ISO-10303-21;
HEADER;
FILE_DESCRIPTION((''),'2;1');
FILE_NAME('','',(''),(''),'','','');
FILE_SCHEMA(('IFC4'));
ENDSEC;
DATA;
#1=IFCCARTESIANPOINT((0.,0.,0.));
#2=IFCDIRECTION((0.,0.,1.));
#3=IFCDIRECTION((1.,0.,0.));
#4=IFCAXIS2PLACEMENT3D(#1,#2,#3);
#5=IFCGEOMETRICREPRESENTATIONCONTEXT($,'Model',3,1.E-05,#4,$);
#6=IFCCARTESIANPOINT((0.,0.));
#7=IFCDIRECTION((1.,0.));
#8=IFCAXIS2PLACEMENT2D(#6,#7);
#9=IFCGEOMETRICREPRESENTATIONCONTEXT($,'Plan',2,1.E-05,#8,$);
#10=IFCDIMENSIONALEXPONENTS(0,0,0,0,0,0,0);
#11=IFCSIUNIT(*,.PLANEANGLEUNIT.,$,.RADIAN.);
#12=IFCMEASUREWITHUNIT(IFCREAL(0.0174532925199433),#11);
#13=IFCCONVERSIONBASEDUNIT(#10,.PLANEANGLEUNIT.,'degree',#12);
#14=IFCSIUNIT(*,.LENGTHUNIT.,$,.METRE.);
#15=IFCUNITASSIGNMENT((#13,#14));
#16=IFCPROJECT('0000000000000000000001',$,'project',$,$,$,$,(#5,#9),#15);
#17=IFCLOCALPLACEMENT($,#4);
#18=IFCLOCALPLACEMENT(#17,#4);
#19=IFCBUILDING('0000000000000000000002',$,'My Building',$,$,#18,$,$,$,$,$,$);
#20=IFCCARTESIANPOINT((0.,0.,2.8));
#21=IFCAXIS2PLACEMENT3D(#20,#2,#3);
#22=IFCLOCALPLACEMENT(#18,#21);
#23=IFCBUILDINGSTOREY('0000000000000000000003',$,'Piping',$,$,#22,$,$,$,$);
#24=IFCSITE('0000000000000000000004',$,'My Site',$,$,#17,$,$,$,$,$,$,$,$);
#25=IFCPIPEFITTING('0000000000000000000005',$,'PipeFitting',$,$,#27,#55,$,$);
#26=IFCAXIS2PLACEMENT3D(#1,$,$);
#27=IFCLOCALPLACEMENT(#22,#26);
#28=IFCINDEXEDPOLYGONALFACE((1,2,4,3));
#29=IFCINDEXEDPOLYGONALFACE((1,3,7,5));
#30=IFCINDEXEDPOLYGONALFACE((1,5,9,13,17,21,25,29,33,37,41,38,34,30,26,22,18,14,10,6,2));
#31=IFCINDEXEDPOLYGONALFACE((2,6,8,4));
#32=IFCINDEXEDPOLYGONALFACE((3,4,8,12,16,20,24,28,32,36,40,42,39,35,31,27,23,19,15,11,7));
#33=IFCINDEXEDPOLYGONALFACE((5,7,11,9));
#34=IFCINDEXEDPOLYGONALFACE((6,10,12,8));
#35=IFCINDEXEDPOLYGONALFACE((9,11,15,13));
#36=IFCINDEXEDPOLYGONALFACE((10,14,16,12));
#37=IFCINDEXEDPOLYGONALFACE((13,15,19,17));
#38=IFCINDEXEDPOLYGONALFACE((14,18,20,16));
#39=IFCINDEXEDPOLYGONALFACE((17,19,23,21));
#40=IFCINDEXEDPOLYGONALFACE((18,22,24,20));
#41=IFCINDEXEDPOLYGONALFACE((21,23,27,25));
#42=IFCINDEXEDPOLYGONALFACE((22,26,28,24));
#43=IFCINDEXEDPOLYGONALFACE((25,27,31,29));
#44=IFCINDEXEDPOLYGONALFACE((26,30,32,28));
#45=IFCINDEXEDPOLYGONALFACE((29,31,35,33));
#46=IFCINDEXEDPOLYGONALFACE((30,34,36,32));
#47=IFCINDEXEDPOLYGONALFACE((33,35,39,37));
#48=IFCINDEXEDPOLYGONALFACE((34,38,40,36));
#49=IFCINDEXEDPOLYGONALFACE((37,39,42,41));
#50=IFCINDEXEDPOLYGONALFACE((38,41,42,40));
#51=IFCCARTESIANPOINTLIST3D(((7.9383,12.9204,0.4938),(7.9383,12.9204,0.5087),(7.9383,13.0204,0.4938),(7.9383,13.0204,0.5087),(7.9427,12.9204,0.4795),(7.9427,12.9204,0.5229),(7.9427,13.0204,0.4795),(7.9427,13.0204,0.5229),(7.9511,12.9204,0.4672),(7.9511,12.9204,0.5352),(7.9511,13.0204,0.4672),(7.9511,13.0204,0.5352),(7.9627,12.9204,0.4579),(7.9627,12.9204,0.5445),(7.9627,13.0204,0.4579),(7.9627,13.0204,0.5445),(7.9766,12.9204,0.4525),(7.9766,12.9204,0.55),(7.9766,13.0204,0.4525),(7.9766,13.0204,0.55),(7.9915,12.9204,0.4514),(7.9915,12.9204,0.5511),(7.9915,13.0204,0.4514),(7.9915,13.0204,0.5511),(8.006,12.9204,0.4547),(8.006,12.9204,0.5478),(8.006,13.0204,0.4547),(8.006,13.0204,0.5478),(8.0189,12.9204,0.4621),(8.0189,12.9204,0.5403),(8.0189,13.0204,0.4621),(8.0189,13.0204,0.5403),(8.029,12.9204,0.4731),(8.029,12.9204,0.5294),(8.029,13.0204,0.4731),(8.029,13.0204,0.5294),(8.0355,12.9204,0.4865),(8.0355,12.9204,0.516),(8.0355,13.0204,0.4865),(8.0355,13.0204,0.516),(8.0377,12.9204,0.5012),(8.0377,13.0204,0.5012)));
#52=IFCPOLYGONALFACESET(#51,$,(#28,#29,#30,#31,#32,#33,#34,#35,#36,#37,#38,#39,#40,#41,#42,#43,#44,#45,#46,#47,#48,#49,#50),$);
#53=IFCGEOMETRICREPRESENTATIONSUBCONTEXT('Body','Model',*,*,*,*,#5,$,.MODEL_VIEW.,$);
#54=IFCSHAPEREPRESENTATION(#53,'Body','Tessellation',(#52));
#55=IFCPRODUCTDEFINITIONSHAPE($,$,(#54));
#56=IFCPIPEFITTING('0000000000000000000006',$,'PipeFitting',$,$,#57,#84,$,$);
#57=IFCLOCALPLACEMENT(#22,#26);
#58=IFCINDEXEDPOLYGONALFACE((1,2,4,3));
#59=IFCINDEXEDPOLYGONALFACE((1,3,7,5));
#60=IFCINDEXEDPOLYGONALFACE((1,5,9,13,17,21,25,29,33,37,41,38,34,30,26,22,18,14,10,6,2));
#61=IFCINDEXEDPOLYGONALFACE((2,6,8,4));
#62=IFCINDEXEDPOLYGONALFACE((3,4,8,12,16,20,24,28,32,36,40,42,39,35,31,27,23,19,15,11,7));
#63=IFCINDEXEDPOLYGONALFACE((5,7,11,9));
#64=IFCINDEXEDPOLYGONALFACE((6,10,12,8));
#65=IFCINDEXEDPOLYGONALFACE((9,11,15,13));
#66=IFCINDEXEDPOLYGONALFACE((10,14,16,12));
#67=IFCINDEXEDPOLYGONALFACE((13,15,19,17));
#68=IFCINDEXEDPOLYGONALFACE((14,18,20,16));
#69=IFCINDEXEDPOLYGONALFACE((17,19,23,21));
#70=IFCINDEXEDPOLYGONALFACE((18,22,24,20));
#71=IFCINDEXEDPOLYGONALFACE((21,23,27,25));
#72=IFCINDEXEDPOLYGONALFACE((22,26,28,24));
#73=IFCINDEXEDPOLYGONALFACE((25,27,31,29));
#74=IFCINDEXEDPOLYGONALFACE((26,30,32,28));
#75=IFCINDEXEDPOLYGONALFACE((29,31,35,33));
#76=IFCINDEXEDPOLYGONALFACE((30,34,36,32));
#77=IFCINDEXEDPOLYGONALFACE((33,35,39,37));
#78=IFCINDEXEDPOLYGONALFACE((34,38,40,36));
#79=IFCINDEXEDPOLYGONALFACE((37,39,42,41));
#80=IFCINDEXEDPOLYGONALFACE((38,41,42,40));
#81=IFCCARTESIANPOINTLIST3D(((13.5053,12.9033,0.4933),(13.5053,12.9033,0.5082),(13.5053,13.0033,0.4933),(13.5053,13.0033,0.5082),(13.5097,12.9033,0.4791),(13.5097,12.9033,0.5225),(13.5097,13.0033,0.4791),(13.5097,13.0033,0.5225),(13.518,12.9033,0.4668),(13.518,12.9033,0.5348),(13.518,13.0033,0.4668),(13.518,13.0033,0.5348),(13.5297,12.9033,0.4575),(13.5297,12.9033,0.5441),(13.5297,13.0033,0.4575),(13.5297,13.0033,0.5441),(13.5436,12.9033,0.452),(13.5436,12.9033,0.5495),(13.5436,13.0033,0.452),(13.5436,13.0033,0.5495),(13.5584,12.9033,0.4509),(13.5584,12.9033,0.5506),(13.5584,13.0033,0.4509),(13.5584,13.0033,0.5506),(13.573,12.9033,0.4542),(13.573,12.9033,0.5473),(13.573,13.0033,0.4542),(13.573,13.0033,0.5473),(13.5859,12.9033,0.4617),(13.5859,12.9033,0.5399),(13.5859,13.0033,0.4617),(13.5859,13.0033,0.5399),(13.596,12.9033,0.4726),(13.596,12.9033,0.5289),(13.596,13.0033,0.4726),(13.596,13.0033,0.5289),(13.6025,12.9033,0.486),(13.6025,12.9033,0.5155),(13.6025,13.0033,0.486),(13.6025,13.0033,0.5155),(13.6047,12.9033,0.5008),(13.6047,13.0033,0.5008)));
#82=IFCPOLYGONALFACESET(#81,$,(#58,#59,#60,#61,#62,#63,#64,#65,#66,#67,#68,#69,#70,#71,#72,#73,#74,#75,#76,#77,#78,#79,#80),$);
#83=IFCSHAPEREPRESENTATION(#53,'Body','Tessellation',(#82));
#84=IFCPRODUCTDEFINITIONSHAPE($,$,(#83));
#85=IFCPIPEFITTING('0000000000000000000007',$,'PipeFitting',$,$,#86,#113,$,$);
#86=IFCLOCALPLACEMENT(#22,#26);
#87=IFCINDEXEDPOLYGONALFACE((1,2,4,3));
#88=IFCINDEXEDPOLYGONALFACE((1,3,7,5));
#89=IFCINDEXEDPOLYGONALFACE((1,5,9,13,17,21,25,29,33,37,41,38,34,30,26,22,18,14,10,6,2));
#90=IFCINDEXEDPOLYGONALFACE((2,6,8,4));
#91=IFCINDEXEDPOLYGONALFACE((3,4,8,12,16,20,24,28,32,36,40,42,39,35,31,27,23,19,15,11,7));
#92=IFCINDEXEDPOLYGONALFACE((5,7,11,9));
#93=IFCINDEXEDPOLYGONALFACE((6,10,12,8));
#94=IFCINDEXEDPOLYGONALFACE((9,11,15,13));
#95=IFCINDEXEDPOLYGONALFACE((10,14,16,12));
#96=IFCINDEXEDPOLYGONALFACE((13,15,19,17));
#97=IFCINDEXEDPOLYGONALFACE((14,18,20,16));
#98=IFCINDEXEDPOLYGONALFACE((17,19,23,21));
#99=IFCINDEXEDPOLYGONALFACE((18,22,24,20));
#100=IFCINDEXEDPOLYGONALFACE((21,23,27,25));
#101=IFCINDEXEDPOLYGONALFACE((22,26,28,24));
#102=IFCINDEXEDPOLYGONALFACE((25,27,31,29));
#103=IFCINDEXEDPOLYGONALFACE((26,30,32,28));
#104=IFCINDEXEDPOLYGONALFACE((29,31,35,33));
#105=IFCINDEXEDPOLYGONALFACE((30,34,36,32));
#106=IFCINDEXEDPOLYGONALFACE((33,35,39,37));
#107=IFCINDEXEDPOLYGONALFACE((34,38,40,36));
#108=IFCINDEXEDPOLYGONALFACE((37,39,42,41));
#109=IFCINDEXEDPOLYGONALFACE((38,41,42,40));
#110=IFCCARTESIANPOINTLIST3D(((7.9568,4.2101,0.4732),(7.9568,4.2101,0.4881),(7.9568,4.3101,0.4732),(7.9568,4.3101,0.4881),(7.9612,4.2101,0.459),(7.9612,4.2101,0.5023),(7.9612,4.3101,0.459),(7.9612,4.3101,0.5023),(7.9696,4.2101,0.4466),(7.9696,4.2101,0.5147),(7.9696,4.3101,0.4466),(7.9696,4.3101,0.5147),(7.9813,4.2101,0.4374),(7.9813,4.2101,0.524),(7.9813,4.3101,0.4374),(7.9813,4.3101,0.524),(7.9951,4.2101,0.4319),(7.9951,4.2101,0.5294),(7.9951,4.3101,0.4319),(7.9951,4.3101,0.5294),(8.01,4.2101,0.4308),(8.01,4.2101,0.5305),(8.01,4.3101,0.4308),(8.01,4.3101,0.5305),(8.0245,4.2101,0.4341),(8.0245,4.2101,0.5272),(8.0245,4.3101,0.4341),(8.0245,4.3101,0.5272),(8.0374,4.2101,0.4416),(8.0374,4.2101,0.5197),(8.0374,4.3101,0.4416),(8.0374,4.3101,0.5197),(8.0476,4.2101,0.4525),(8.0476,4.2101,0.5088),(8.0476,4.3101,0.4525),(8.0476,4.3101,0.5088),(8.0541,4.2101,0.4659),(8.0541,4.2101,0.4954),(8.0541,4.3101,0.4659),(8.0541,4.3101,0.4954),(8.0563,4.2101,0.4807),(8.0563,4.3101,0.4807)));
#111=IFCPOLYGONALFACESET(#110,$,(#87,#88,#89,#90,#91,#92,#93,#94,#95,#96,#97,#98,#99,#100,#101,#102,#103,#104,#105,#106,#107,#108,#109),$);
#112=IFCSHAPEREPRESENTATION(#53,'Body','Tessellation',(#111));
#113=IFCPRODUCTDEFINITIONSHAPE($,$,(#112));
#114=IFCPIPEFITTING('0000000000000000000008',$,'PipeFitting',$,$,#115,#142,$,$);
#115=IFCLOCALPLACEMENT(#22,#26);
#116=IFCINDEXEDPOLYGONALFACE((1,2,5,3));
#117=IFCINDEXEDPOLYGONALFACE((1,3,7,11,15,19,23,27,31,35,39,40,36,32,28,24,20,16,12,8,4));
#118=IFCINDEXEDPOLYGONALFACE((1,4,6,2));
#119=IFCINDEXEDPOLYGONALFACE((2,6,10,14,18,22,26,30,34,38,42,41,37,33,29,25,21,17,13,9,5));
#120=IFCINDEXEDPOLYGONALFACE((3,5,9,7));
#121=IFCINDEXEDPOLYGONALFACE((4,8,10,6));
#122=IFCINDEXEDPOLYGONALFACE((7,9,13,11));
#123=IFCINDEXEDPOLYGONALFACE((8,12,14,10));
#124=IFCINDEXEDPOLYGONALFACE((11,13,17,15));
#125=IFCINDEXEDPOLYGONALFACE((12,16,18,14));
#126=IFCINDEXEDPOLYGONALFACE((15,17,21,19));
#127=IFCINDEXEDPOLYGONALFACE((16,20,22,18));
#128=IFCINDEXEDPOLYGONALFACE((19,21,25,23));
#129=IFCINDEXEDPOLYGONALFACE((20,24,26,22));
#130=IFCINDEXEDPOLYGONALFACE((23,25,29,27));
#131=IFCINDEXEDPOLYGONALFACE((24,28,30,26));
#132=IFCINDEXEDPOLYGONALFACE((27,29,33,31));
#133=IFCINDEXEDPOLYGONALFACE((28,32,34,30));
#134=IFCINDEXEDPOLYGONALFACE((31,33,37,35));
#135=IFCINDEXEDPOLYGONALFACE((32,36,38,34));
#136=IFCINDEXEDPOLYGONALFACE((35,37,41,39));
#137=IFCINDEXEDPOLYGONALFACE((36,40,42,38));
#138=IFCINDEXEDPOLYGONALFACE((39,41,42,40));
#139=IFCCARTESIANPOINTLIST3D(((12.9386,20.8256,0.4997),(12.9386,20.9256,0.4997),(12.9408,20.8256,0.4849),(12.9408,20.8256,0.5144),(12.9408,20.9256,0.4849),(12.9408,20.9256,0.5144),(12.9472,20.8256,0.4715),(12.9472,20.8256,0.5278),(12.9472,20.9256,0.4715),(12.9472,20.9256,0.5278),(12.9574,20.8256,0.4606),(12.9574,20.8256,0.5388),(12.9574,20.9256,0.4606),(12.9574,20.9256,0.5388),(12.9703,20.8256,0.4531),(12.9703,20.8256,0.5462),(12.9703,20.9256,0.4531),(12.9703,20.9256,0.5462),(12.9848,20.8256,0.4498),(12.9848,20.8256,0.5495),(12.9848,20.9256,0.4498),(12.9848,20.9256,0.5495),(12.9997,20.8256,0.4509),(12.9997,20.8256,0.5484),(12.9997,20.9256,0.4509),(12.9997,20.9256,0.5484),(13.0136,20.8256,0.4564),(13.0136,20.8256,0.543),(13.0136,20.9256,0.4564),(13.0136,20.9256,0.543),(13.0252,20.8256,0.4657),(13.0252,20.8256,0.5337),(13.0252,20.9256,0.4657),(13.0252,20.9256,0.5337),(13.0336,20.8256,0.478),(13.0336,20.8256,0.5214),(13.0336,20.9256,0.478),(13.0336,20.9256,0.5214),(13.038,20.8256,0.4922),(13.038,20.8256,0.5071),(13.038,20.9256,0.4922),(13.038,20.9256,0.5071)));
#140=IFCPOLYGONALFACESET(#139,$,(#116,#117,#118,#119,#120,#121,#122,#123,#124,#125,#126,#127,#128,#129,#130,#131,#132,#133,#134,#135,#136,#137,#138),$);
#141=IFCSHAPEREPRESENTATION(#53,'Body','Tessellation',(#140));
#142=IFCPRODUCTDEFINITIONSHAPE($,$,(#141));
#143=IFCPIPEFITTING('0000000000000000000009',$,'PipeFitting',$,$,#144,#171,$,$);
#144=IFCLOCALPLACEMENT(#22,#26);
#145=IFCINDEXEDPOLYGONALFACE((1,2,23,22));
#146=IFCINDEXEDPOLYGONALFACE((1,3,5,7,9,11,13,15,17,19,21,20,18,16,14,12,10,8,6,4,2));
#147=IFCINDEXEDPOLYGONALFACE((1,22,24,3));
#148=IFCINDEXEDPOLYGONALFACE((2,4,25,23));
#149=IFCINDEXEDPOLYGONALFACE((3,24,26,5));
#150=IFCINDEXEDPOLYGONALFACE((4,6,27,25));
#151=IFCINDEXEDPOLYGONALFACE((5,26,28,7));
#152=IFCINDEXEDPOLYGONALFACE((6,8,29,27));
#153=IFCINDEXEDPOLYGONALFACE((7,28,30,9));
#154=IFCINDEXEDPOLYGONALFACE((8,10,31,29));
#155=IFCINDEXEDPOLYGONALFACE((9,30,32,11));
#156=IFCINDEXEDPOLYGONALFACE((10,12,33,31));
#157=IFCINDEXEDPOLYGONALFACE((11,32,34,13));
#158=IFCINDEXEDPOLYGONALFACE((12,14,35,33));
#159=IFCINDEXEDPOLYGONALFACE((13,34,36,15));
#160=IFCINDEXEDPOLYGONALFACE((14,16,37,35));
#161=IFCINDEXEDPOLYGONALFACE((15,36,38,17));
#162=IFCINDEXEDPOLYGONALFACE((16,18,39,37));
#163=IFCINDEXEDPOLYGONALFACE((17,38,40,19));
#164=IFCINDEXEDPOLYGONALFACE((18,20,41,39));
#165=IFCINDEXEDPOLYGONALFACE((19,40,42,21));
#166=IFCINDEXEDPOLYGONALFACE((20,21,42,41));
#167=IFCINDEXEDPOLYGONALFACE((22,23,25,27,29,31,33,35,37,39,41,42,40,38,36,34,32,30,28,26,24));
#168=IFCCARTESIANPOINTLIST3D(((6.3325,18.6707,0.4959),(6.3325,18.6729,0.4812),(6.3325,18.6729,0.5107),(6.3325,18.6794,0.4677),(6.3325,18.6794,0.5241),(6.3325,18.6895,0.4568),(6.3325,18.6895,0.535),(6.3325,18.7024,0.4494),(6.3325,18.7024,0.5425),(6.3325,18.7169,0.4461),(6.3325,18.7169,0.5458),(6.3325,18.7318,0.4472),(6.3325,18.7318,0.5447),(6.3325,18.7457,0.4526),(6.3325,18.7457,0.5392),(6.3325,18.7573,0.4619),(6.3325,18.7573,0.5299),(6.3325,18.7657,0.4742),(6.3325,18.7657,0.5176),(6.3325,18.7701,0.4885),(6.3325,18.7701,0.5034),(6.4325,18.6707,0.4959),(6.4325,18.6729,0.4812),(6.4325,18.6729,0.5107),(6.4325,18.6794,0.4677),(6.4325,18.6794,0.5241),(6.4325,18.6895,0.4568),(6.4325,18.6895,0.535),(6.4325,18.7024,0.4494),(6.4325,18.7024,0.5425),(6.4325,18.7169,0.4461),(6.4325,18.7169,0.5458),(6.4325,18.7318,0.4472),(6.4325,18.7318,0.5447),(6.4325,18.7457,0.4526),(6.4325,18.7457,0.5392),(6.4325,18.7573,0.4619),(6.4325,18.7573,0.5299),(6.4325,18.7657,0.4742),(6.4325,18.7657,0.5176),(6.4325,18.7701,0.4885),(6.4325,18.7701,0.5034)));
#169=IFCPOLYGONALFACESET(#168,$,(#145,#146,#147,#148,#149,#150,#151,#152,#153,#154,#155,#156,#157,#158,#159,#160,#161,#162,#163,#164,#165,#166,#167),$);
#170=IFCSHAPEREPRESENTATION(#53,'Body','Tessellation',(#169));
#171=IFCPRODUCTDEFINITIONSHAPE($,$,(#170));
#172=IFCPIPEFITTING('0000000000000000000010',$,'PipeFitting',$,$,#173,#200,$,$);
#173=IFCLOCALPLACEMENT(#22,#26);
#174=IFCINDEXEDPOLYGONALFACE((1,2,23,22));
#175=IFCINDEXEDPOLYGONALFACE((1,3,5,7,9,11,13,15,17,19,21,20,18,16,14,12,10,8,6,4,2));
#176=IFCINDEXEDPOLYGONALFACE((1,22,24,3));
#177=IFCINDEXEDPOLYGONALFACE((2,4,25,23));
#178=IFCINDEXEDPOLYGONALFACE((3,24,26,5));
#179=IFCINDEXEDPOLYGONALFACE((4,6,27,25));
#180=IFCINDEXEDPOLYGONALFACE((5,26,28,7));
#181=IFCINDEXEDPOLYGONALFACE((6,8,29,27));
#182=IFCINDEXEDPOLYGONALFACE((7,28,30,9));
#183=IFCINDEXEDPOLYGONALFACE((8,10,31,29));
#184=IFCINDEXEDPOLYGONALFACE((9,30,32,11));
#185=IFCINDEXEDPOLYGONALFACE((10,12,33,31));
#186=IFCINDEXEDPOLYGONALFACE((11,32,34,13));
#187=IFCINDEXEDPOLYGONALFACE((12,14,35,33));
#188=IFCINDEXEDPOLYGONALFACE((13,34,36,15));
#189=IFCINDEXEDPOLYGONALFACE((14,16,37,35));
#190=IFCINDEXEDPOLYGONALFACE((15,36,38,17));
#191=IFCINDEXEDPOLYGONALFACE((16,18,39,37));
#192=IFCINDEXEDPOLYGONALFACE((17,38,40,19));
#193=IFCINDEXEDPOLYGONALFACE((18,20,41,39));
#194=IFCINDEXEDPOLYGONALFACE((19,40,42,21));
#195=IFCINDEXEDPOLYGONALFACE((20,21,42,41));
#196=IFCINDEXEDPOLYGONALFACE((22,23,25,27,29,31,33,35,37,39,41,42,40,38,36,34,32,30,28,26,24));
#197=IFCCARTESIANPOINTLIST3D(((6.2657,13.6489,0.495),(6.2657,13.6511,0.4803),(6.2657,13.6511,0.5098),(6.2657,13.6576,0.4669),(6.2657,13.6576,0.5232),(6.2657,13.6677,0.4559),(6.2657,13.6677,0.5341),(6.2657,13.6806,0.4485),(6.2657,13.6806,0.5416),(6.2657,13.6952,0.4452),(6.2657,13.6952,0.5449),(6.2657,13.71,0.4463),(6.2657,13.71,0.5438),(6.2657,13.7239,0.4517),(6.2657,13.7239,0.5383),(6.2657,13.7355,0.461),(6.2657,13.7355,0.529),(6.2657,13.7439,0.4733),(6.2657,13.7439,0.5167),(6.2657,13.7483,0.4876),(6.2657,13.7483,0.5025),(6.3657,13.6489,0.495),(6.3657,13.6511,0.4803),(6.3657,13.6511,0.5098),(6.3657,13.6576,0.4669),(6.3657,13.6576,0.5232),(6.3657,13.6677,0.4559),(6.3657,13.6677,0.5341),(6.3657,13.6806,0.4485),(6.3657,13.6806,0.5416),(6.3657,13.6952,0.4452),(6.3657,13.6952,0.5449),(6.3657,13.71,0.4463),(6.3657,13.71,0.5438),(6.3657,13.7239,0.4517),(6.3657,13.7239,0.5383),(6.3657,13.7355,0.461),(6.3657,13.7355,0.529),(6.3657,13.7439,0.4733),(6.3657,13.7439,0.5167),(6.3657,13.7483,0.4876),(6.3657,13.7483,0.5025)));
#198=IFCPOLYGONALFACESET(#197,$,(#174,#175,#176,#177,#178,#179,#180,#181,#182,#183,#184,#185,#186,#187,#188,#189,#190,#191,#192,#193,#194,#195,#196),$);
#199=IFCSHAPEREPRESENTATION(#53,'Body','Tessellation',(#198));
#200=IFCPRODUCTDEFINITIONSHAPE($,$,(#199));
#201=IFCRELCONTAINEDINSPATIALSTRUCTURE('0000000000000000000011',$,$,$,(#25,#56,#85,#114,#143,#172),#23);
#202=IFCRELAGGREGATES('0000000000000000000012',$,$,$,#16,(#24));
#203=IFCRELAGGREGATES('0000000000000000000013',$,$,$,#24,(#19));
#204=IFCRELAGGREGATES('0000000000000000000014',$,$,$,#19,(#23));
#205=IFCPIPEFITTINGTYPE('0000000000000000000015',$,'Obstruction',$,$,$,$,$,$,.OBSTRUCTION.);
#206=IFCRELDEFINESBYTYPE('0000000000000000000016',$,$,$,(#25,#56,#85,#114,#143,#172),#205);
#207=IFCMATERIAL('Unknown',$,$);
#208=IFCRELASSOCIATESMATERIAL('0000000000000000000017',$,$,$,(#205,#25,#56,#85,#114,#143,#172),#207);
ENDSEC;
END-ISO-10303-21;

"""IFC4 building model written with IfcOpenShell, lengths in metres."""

from ifc_helpers import new_model, entity, si_unit, converted_unit, frame, origin_with_axes, origin_2d_with_axis, place, context, subcontext, project, spatial, circle, extrude, material, material_profile, profile_set, profile_usage, type_object, element, save


model = new_model("IFC4")

# Units and contexts
model_context = context("Model", 3, precision=1e-05, world=origin_with_axes())
plan_context = context("Plan", 2, precision=1e-05, world=origin_2d_with_axis())
body_context = subcontext(model_context, "Body", "Model", "MODEL_VIEW")
ifc_project = project(units=[converted_unit("PLANEANGLEUNIT", "degree", entity("IfcReal", 0.0174532925199433), si_unit("PLANEANGLEUNIT", "RADIAN"), dimensions=[0, 0, 0, 0, 0, 0, 0]), si_unit("LENGTHUNIT", "METRE")], contexts=[model_context, plan_context])

# Site, building, storey
site_placement = place(None, origin_with_axes())
site = spatial("IfcSite", under=ifc_project, at=site_placement, Name="My Site")
building_placement = place(site_placement, origin_with_axes())
building = spatial("IfcBuilding", under=site, at=building_placement, Name="My Building")
storey_placement = place(building_placement, frame((0.0, 0.0, 2.8), z_axis=(0.0, 0.0, 1.0), x_axis=(1.0, 0.0, 0.0)))
storey = spatial("IfcBuildingStorey", under=building, at=storey_placement, Name="Piping")

# Shared definitions
ifc_material = material(Name="Unknown")

# Pipe fittings
ifc_material_profile_1 = material_profile(ifc_material, circle(Radius=0.05))
ifc_profile_set_1 = profile_set([ifc_material_profile_1])
ifc_profile_usage_1 = profile_usage(ifc_profile_set_1, cardinal=5)
pipe_fitting_type_1 = type_object("IfcPipeFittingType", Name="Obstruction", PredefinedType="OBSTRUCTION", material=ifc_profile_set_1)
pipe_fitting_1_placement = place(storey_placement, frame((7.9877, 13.0204, 0.5012), z_axis=(0.0, -1.0, 0.0), x_axis=(1.0, 0.0, 0.0)))
element("IfcPipeFitting", 1, at=pipe_fitting_1_placement, inside=storey, type_object=pipe_fitting_type_1, material=ifc_profile_usage_1, Name="PipeFitting", context=body_context, shape_type="SweptSolid", body=[
    extrude(circle(Radius=0.05), origin_with_axes(), (0.0, 0.0, 1.0), 0.1),
])
ifc_profile_usage_2 = profile_usage(ifc_profile_set_1, cardinal=5)
pipe_fitting_2_placement = place(storey_placement, frame((13.5547, 13.0033, 0.5008), z_axis=(0.0, -1.0, 0.0), x_axis=(1.0, 0.0, 0.0)))
element("IfcPipeFitting", 2, at=pipe_fitting_2_placement, inside=storey, type_object=pipe_fitting_type_1, material=ifc_profile_usage_2, Name="PipeFitting", context=body_context, shape_type="SweptSolid", body=[
    extrude(circle(Radius=0.05), origin_with_axes(), (0.0, 0.0, 1.0), 0.1),
])
ifc_profile_usage_3 = profile_usage(ifc_profile_set_1, cardinal=5)
pipe_fitting_3_placement = place(storey_placement, frame((8.0063, 4.3101, 0.4807), z_axis=(0.0, -1.0, 0.0), x_axis=(1.0, 0.0, 0.0)))
element("IfcPipeFitting", 3, at=pipe_fitting_3_placement, inside=storey, type_object=pipe_fitting_type_1, material=ifc_profile_usage_3, Name="PipeFitting", context=body_context, shape_type="SweptSolid", body=[
    extrude(circle(Radius=0.05), origin_with_axes(), (0.0, 0.0, 1.0), 0.1),
])
ifc_profile_usage_4 = profile_usage(ifc_profile_set_1, cardinal=5)
pipe_fitting_4_placement = place(storey_placement, frame((12.9886, 20.8256, 0.4997), z_axis=(0.0, 1.0, 0.0), x_axis=(-1.0, 0.0, 0.0)))
element("IfcPipeFitting", 4, at=pipe_fitting_4_placement, inside=storey, type_object=pipe_fitting_type_1, material=ifc_profile_usage_4, Name="PipeFitting", context=body_context, shape_type="SweptSolid", body=[
    extrude(circle(Radius=0.05), origin_with_axes(), (0.0, 0.0, 1.0), 0.1),
])
ifc_profile_usage_5 = profile_usage(ifc_profile_set_1, cardinal=5)
pipe_fitting_5_placement = place(storey_placement, frame((6.4325, 18.7207, 0.4959), z_axis=(-1.0, 0.0, 0.0), x_axis=(0.0, -1.0, 0.0)))
element("IfcPipeFitting", 5, at=pipe_fitting_5_placement, inside=storey, type_object=pipe_fitting_type_1, material=ifc_profile_usage_5, Name="PipeFitting", context=body_context, shape_type="SweptSolid", body=[
    extrude(circle(Radius=0.05), origin_with_axes(), (0.0, 0.0, 1.0), 0.1),
])
ifc_profile_usage_6 = profile_usage(ifc_profile_set_1, cardinal=5)
pipe_fitting_6_placement = place(storey_placement, frame((6.3657, 13.6989, 0.495), z_axis=(-1.0, 0.0, 0.0), x_axis=(0.0, -1.0, 0.0)))
element("IfcPipeFitting", 6, at=pipe_fitting_6_placement, inside=storey, type_object=pipe_fitting_type_1, material=ifc_profile_usage_6, Name="PipeFitting", context=body_context, shape_type="SweptSolid", body=[
    extrude(circle(Radius=0.05), origin_with_axes(), (0.0, 0.0, 1.0), 0.1),
])

save(model, "model.ifc")
